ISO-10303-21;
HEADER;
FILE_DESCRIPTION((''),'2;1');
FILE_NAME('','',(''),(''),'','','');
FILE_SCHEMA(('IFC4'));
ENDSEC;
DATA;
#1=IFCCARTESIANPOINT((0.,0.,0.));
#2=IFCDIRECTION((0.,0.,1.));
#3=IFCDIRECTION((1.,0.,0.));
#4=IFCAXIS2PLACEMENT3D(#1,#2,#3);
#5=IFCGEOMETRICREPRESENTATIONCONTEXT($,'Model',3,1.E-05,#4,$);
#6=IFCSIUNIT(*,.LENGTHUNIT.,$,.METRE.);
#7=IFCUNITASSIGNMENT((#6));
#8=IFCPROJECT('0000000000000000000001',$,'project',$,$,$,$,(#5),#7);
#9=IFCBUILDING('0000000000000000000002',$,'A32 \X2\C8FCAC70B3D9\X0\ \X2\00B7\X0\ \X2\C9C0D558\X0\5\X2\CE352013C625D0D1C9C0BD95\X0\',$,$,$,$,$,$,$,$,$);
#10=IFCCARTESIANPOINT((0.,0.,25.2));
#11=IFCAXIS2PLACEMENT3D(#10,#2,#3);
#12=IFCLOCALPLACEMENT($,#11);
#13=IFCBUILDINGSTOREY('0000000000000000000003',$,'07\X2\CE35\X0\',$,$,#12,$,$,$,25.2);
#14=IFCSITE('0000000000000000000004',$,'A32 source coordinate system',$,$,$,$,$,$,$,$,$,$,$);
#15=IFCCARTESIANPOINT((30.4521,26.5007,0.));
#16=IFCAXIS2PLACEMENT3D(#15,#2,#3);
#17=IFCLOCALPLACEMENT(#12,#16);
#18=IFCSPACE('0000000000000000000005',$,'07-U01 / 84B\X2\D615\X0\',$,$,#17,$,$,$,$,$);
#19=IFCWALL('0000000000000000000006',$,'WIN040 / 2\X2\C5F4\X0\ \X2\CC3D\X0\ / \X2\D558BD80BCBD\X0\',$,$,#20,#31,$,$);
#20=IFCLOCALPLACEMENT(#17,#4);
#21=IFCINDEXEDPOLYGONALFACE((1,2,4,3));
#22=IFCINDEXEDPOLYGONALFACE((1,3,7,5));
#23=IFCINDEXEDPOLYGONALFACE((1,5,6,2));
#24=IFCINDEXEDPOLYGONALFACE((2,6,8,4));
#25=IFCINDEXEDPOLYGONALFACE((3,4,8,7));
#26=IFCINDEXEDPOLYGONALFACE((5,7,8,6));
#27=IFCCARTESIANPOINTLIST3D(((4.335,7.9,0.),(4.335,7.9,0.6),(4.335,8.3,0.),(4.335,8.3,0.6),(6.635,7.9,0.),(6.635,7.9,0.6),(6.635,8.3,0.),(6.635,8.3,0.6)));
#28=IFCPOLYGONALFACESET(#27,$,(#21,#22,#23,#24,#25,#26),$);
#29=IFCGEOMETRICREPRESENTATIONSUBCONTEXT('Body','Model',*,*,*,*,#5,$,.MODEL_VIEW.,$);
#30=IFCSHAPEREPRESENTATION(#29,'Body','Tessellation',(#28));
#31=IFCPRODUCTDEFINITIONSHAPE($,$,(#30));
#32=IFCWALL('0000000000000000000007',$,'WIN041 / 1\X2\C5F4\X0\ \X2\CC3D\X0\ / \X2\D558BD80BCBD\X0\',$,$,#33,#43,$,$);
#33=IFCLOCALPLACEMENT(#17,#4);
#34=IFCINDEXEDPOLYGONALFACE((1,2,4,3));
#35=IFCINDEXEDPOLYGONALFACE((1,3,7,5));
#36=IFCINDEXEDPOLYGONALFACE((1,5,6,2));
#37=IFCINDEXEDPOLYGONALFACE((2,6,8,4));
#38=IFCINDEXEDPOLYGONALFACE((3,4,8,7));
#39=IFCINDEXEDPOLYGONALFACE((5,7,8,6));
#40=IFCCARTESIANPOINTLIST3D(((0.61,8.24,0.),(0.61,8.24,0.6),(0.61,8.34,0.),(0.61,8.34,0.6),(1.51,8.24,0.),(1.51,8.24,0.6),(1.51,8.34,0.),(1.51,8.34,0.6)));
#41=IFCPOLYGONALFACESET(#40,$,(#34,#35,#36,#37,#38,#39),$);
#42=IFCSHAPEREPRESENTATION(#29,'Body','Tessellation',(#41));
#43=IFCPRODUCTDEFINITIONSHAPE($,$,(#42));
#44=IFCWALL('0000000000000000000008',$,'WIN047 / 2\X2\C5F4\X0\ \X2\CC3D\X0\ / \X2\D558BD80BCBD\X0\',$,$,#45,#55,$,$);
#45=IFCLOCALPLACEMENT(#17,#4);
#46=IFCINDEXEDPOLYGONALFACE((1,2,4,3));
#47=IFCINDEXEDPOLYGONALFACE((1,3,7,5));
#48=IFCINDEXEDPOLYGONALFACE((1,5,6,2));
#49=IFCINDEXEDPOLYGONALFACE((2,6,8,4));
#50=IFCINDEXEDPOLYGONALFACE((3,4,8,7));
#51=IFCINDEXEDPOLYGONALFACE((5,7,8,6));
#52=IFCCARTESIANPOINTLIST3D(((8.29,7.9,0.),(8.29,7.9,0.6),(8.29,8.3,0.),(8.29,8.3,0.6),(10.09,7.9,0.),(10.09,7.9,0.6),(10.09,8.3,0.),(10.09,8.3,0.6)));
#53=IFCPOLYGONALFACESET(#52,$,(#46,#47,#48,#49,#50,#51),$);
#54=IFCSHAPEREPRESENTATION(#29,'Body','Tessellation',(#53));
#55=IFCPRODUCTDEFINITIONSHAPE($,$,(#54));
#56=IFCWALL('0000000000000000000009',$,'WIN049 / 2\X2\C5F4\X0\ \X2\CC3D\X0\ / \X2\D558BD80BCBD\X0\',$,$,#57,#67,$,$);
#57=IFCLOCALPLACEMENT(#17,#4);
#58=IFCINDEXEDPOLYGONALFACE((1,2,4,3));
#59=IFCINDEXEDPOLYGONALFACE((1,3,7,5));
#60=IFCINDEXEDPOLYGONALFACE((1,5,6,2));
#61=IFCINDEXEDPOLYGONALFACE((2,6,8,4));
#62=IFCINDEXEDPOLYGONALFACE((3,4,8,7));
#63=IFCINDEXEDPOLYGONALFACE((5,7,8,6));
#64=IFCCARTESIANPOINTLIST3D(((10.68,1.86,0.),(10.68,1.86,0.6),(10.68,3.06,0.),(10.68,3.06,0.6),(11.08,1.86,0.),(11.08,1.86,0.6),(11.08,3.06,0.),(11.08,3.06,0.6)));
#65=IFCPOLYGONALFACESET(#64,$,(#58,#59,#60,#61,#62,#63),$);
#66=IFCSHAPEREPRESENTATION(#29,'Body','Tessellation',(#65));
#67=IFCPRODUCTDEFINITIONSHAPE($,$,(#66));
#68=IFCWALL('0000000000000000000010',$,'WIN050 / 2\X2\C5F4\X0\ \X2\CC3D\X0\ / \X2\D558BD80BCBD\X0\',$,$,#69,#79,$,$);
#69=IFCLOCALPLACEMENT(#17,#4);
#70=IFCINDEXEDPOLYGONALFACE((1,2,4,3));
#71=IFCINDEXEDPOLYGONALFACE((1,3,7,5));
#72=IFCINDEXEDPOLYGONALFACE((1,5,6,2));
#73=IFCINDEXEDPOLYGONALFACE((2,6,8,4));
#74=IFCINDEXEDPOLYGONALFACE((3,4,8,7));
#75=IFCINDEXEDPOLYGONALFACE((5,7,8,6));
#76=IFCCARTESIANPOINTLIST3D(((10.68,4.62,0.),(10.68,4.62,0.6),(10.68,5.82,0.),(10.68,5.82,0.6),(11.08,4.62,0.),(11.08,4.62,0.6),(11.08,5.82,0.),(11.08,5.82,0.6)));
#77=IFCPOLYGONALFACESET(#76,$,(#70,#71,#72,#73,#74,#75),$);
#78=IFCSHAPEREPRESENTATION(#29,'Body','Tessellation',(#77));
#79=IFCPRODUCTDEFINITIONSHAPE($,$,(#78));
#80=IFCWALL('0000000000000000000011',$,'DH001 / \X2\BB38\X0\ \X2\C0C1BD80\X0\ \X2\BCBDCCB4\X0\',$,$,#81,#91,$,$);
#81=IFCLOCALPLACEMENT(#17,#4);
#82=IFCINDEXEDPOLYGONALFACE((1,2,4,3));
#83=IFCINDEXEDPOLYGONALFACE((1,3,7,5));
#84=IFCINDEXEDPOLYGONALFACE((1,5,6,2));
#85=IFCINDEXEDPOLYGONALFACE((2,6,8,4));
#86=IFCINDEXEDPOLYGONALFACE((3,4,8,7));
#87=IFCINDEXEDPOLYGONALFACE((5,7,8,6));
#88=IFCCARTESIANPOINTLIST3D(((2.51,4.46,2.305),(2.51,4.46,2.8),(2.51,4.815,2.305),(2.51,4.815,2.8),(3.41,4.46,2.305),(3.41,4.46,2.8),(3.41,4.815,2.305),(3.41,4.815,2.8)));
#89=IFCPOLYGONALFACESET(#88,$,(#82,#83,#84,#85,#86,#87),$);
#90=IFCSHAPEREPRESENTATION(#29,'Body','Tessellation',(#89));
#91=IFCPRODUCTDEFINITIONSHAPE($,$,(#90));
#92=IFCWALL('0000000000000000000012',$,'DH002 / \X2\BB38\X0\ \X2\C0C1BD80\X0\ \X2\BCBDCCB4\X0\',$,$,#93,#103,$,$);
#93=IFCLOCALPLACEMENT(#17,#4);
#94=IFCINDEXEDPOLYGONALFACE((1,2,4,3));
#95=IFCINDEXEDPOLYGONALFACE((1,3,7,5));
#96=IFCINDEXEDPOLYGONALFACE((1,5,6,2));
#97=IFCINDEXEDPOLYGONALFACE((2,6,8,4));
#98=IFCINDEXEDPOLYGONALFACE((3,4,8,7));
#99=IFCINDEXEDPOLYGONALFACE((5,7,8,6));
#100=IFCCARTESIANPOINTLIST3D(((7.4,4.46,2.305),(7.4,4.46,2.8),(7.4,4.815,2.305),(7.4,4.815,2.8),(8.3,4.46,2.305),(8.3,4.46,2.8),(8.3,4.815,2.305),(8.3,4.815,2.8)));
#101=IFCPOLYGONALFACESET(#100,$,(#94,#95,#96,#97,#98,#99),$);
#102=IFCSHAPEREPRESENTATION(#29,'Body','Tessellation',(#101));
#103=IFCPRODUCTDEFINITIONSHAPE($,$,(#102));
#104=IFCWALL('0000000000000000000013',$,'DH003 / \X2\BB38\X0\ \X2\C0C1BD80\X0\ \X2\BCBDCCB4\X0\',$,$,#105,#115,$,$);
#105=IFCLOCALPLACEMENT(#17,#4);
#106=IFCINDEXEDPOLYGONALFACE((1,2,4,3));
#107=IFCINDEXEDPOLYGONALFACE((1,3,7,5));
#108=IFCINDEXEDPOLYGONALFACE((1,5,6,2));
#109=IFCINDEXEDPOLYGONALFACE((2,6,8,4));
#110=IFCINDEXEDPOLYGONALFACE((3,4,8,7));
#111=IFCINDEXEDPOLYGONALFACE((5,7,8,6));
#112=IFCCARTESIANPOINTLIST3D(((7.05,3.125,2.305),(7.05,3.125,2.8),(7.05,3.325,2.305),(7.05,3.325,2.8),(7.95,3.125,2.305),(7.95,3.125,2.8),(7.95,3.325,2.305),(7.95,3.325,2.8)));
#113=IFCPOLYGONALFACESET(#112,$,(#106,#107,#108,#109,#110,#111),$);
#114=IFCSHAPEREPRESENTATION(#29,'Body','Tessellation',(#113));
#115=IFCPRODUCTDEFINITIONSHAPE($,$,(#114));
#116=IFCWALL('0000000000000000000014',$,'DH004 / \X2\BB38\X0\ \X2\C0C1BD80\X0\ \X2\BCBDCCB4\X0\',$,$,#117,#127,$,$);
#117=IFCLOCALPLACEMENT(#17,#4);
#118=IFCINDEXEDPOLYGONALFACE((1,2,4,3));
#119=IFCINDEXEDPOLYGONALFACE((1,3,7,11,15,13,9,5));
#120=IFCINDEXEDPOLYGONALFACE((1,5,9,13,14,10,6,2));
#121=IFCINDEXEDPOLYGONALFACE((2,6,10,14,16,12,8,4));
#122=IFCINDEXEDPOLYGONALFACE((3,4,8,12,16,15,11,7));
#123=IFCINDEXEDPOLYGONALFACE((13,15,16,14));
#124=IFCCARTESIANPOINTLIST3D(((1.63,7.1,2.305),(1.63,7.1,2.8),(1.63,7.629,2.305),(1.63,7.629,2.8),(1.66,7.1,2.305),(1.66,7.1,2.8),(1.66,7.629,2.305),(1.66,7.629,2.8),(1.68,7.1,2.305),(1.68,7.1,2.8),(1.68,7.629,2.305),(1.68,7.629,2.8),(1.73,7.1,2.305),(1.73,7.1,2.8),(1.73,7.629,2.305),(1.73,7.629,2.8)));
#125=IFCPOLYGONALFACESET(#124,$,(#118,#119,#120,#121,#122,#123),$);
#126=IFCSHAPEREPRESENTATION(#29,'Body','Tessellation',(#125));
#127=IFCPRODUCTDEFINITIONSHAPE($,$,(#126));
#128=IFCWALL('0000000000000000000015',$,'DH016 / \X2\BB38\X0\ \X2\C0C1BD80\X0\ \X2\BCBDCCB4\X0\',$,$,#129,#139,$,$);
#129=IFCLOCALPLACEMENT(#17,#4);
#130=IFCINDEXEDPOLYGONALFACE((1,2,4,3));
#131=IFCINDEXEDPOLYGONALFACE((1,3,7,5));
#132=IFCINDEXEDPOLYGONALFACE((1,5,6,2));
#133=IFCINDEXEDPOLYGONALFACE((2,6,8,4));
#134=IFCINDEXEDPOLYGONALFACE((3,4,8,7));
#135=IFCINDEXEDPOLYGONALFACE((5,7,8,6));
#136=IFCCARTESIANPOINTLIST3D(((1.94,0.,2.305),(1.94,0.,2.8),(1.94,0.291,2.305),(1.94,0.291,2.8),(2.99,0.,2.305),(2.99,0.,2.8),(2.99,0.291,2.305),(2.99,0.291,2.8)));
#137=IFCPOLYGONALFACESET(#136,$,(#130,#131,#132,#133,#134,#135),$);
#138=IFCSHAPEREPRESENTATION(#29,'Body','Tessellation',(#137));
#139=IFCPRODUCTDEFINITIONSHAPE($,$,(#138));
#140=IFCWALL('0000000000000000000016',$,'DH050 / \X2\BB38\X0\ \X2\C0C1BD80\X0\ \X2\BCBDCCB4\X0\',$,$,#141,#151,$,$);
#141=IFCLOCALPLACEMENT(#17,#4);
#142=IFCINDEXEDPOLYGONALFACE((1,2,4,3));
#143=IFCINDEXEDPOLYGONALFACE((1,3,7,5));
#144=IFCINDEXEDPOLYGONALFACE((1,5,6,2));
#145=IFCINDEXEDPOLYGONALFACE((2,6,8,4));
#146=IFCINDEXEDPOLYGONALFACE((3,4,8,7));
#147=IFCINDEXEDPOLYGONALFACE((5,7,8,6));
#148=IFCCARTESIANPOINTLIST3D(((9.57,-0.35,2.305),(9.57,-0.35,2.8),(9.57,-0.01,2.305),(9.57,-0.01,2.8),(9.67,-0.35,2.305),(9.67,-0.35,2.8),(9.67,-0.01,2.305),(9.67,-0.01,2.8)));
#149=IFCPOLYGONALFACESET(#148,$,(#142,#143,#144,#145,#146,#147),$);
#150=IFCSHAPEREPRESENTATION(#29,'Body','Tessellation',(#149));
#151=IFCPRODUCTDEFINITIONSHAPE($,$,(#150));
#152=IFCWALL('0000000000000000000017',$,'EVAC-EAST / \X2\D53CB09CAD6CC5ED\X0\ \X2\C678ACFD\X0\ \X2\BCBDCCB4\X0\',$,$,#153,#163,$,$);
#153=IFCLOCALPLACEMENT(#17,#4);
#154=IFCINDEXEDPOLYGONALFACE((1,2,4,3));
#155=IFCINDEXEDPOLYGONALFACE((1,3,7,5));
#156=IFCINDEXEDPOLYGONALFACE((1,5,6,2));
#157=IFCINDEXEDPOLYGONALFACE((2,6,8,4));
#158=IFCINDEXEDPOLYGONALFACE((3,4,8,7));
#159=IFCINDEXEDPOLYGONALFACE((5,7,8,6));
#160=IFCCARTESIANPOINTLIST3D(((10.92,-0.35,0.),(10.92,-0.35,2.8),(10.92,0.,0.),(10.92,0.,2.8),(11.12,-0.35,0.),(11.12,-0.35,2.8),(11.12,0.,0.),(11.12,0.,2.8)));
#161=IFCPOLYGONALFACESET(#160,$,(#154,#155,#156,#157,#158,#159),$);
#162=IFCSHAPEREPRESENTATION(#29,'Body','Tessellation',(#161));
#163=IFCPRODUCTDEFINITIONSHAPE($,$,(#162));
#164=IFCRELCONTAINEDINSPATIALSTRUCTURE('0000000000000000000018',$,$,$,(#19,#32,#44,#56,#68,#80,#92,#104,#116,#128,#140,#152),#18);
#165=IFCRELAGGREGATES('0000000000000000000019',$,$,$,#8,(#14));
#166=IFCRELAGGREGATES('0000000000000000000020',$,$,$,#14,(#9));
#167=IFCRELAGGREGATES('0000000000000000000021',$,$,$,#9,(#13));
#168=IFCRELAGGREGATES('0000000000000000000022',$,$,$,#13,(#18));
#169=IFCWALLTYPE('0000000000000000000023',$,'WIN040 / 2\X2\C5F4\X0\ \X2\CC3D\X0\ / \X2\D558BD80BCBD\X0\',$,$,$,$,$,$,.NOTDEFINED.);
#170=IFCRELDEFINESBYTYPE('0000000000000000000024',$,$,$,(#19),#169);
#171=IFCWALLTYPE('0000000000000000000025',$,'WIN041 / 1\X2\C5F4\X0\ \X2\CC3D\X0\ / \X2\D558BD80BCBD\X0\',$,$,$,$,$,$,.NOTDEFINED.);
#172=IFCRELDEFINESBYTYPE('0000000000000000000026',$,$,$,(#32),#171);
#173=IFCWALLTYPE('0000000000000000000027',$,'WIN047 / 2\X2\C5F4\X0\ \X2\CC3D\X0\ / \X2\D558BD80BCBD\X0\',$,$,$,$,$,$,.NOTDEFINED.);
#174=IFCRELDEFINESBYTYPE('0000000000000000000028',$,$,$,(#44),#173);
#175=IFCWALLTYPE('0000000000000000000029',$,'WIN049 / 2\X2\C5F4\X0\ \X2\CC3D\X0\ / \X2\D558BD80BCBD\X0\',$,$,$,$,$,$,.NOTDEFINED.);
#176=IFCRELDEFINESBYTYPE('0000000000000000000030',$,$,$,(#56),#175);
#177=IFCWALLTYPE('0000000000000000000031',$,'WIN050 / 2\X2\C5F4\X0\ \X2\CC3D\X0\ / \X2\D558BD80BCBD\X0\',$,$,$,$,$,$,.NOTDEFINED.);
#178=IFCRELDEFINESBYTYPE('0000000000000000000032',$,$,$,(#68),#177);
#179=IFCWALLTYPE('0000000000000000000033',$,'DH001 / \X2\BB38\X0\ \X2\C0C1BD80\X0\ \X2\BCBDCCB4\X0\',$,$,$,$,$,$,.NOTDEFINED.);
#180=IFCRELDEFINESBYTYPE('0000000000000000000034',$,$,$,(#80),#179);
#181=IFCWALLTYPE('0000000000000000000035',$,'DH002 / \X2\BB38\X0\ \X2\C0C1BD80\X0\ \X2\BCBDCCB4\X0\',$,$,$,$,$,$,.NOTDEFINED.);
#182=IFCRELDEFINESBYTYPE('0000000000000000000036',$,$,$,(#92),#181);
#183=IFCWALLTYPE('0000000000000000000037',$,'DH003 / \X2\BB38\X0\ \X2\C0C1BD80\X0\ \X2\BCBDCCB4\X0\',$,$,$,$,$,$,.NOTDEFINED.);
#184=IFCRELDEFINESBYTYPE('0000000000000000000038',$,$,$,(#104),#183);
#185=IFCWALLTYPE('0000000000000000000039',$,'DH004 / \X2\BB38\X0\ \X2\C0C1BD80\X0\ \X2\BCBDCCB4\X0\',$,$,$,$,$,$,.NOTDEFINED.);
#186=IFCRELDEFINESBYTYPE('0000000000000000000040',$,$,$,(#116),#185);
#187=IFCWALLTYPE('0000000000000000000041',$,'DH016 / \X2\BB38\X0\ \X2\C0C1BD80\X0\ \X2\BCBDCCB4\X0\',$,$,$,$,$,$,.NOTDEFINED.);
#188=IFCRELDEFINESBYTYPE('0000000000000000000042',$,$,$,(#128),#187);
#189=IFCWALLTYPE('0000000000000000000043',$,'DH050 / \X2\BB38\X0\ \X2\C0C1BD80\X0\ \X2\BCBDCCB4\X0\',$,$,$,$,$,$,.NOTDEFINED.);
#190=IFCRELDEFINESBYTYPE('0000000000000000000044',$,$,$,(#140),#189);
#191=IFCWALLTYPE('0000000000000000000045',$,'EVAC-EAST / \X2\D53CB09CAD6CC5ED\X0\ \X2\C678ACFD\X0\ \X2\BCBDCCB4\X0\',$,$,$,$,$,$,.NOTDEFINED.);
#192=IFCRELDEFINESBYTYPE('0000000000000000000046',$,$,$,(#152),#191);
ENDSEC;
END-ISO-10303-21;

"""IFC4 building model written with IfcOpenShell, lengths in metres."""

from ifc_helpers import new_model, si_unit, frame, origin, origin_with_axes, place, context, subcontext, project, spatial, polyline, outline, extrude, source, transform, mapped, type_object, type_shapes, element, save


model = new_model("IFC4")

# Units and contexts
model_context = context("Model", 3, precision=1e-05, world=origin_with_axes())
body_context = subcontext(model_context, "Body", "Model", "MODEL_VIEW")
ifc_project = project(units=[si_unit("LENGTHUNIT", "METRE")], contexts=[model_context])

# Site, building, storey, space
site = spatial("IfcSite", under=ifc_project, Name="A32 source coordinate system")
building = spatial("IfcBuilding", under=site, Name="A32 주거동 · 지하5층–옥탑지붕")
storey_placement = place(None, frame((0.0, 0.0, 25.2), z_axis=(0.0, 0.0, 1.0), x_axis=(1.0, 0.0, 0.0)))
storey = spatial("IfcBuildingStorey", under=building, at=storey_placement, Name="07층", Elevation=25.2)
space_placement = place(storey_placement, frame((30.4521, 26.5007, 0.0), z_axis=(0.0, 0.0, 1.0), x_axis=(1.0, 0.0, 0.0)))
space = spatial("IfcSpace", under=storey, at=space_placement, Name="07-U01 / 84B형")

# Walls
wall_type_1 = type_object("IfcWallType", Name="WIN040 / 2열 창 / 하부벽", PredefinedType="NOTDEFINED")
shared_shape_1 = source(origin(), body_context, "Body", "SweptSolid", [
    extrude(outline(polyline([(4.335, 8.3), (6.635, 8.3), (6.635, 7.9), (4.335, 7.9), (4.335, 8.3)])), origin(), (0.0, 0.0, 1.0), 0.6),
])
type_shapes(wall_type_1, [shared_shape_1])
wall_1_placement = place(space_placement, origin_with_axes())
element("IfcWall", 1, at=wall_1_placement, inside=space, type_object=wall_type_1, Name="WIN040 / 2열 창 / 하부벽", context=body_context, shape_type="MappedRepresentation", body=[
    mapped(shared_shape_1, transform((0.0, 0.0, 0.0), scale=1.0)),
])
wall_type_2 = type_object("IfcWallType", Name="WIN041 / 1열 창 / 하부벽", PredefinedType="NOTDEFINED")
shared_shape_2 = source(origin(), body_context, "Body", "SweptSolid", [
    extrude(outline(polyline([(0.61, 8.34), (1.51, 8.34), (1.51, 8.24), (0.61, 8.24), (0.61, 8.34)])), origin(), (0.0, 0.0, 1.0), 0.6),
])
type_shapes(wall_type_2, [shared_shape_2])
wall_2_placement = place(space_placement, origin_with_axes())
element("IfcWall", 2, at=wall_2_placement, inside=space, type_object=wall_type_2, Name="WIN041 / 1열 창 / 하부벽", context=body_context, shape_type="MappedRepresentation", body=[
    mapped(shared_shape_2, transform((0.0, 0.0, 0.0), scale=1.0)),
])
wall_type_3 = type_object("IfcWallType", Name="WIN047 / 2열 창 / 하부벽", PredefinedType="NOTDEFINED")
shared_shape_3 = source(origin(), body_context, "Body", "SweptSolid", [
    extrude(outline(polyline([(8.29, 8.3), (10.09, 8.3), (10.09, 7.9), (8.29, 7.9), (8.29, 8.3)])), origin(), (0.0, 0.0, 1.0), 0.6),
])
type_shapes(wall_type_3, [shared_shape_3])
wall_3_placement = place(space_placement, origin_with_axes())
element("IfcWall", 3, at=wall_3_placement, inside=space, type_object=wall_type_3, Name="WIN047 / 2열 창 / 하부벽", context=body_context, shape_type="MappedRepresentation", body=[
    mapped(shared_shape_3, transform((0.0, 0.0, 0.0), scale=1.0)),
])
wall_type_4 = type_object("IfcWallType", Name="WIN049 / 2열 창 / 하부벽", PredefinedType="NOTDEFINED")
shared_shape_4 = source(origin(), body_context, "Body", "SweptSolid", [
    extrude(outline(polyline([(10.68, 3.06), (11.08, 3.06), (11.08, 1.86), (10.68, 1.86), (10.68, 3.06)])), origin(), (0.0, 0.0, 1.0), 0.6),
])
type_shapes(wall_type_4, [shared_shape_4])
wall_4_placement = place(space_placement, origin_with_axes())
element("IfcWall", 4, at=wall_4_placement, inside=space, type_object=wall_type_4, Name="WIN049 / 2열 창 / 하부벽", context=body_context, shape_type="MappedRepresentation", body=[
    mapped(shared_shape_4, transform((0.0, 0.0, 0.0), scale=1.0)),
])
wall_type_5 = type_object("IfcWallType", Name="WIN050 / 2열 창 / 하부벽", PredefinedType="NOTDEFINED")
shared_shape_5 = source(origin(), body_context, "Body", "SweptSolid", [
    extrude(outline(polyline([(10.68, 5.82), (11.08, 5.82), (11.08, 4.62), (10.68, 4.62), (10.68, 5.82)])), origin(), (0.0, 0.0, 1.0), 0.6),
])
type_shapes(wall_type_5, [shared_shape_5])
wall_5_placement = place(space_placement, origin_with_axes())
element("IfcWall", 5, at=wall_5_placement, inside=space, type_object=wall_type_5, Name="WIN050 / 2열 창 / 하부벽", context=body_context, shape_type="MappedRepresentation", body=[
    mapped(shared_shape_5, transform((0.0, 0.0, 0.0), scale=1.0)),
])
wall_type_6 = type_object("IfcWallType", Name="DH001 / 문 상부 벽체", PredefinedType="NOTDEFINED")
shared_shape_6 = source(origin(), body_context, "Body", "SweptSolid", [
    extrude(outline(polyline([(3.41, 4.815), (3.41, 4.46), (2.51, 4.46), (2.51, 4.815), (3.41, 4.815)])), frame((0.0, 0.0, 2.305)), (0.0, 0.0, 1.0), 0.495),
])
type_shapes(wall_type_6, [shared_shape_6])
wall_6_placement = place(space_placement, origin_with_axes())
element("IfcWall", 6, at=wall_6_placement, inside=space, type_object=wall_type_6, Name="DH001 / 문 상부 벽체", context=body_context, shape_type="MappedRepresentation", body=[
    mapped(shared_shape_6, transform((0.0, 0.0, 0.0), scale=1.0)),
])
wall_type_7 = type_object("IfcWallType", Name="DH002 / 문 상부 벽체", PredefinedType="NOTDEFINED")
shared_shape_7 = source(origin(), body_context, "Body", "SweptSolid", [
    extrude(outline(polyline([(8.3, 4.815), (8.3, 4.46), (7.4, 4.46), (7.4, 4.815), (8.3, 4.815)])), frame((0.0, 0.0, 2.305)), (0.0, 0.0, 1.0), 0.495),
])
type_shapes(wall_type_7, [shared_shape_7])
wall_7_placement = place(space_placement, origin_with_axes())
element("IfcWall", 7, at=wall_7_placement, inside=space, type_object=wall_type_7, Name="DH002 / 문 상부 벽체", context=body_context, shape_type="MappedRepresentation", body=[
    mapped(shared_shape_7, transform((0.0, 0.0, 0.0), scale=1.0)),
])
wall_type_8 = type_object("IfcWallType", Name="DH003 / 문 상부 벽체", PredefinedType="NOTDEFINED")
shared_shape_8 = source(origin(), body_context, "Body", "SweptSolid", [
    extrude(outline(polyline([(7.95, 3.325), (7.95, 3.125), (7.05, 3.125), (7.05, 3.325), (7.95, 3.325)])), frame((0.0, 0.0, 2.305)), (0.0, 0.0, 1.0), 0.495),
])
type_shapes(wall_type_8, [shared_shape_8])
wall_8_placement = place(space_placement, origin_with_axes())
element("IfcWall", 8, at=wall_8_placement, inside=space, type_object=wall_type_8, Name="DH003 / 문 상부 벽체", context=body_context, shape_type="MappedRepresentation", body=[
    mapped(shared_shape_8, transform((0.0, 0.0, 0.0), scale=1.0)),
])
wall_type_9 = type_object("IfcWallType", Name="DH004 / 문 상부 벽체", PredefinedType="NOTDEFINED")
shared_shape_9 = source(origin(), body_context, "Body", "SweptSolid", [
    extrude(outline(polyline([(1.66, 7.1), (1.63, 7.1), (1.63, 7.629), (1.66, 7.629), (1.68, 7.629), (1.73, 7.629), (1.73, 7.1), (1.68, 7.1), (1.66, 7.1)])), frame((0.0, 0.0, 2.305)), (0.0, 0.0, 1.0), 0.495),
])
type_shapes(wall_type_9, [shared_shape_9])
wall_9_placement = place(space_placement, origin_with_axes())
element("IfcWall", 9, at=wall_9_placement, inside=space, type_object=wall_type_9, Name="DH004 / 문 상부 벽체", context=body_context, shape_type="MappedRepresentation", body=[
    mapped(shared_shape_9, transform((0.0, 0.0, 0.0), scale=1.0)),
])
wall_type_10 = type_object("IfcWallType", Name="DH016 / 문 상부 벽체", PredefinedType="NOTDEFINED")
shared_shape_10 = source(origin(), body_context, "Body", "SweptSolid", [
    extrude(outline(polyline([(2.99, 0.291), (2.99, 0.0), (1.94, 0.0), (1.94, 0.291), (2.99, 0.291)])), frame((0.0, 0.0, 2.305)), (0.0, 0.0, 1.0), 0.495),
])
type_shapes(wall_type_10, [shared_shape_10])
wall_10_placement = place(space_placement, origin_with_axes())
element("IfcWall", 10, at=wall_10_placement, inside=space, type_object=wall_type_10, Name="DH016 / 문 상부 벽체", context=body_context, shape_type="MappedRepresentation", body=[
    mapped(shared_shape_10, transform((0.0, 0.0, 0.0), scale=1.0)),
])
wall_type_11 = type_object("IfcWallType", Name="DH050 / 문 상부 벽체", PredefinedType="NOTDEFINED")
shared_shape_11 = source(origin(), body_context, "Body", "SweptSolid", [
    extrude(outline(polyline([(9.67, -0.01), (9.67, -0.35), (9.57, -0.35), (9.57, -0.01), (9.67, -0.01)])), frame((0.0, 0.0, 2.305)), (0.0, 0.0, 1.0), 0.495),
])
type_shapes(wall_type_11, [shared_shape_11])
wall_11_placement = place(space_placement, origin_with_axes())
element("IfcWall", 11, at=wall_11_placement, inside=space, type_object=wall_type_11, Name="DH050 / 문 상부 벽체", context=body_context, shape_type="MappedRepresentation", body=[
    mapped(shared_shape_11, transform((0.0, 0.0, 0.0), scale=1.0)),
])
wall_type_12 = type_object("IfcWallType", Name="EVAC-EAST / 피난구역 외곽 벽체", PredefinedType="NOTDEFINED")
shared_shape_12 = source(origin(), body_context, "Body", "SweptSolid", [
    extrude(outline(polyline([(10.92, 0.0), (11.12, 0.0), (11.12, -0.35), (10.92, -0.35), (10.92, 0.0)])), origin(), (0.0, 0.0, 1.0), 2.8),
])
type_shapes(wall_type_12, [shared_shape_12])
wall_12_placement = place(space_placement, origin_with_axes())
element("IfcWall", 12, at=wall_12_placement, inside=space, type_object=wall_type_12, Name="EVAC-EAST / 피난구역 외곽 벽체", context=body_context, shape_type="MappedRepresentation", body=[
    mapped(shared_shape_12, transform((0.0, 0.0, 0.0), scale=1.0)),
])

save(model, "model.ifc")
